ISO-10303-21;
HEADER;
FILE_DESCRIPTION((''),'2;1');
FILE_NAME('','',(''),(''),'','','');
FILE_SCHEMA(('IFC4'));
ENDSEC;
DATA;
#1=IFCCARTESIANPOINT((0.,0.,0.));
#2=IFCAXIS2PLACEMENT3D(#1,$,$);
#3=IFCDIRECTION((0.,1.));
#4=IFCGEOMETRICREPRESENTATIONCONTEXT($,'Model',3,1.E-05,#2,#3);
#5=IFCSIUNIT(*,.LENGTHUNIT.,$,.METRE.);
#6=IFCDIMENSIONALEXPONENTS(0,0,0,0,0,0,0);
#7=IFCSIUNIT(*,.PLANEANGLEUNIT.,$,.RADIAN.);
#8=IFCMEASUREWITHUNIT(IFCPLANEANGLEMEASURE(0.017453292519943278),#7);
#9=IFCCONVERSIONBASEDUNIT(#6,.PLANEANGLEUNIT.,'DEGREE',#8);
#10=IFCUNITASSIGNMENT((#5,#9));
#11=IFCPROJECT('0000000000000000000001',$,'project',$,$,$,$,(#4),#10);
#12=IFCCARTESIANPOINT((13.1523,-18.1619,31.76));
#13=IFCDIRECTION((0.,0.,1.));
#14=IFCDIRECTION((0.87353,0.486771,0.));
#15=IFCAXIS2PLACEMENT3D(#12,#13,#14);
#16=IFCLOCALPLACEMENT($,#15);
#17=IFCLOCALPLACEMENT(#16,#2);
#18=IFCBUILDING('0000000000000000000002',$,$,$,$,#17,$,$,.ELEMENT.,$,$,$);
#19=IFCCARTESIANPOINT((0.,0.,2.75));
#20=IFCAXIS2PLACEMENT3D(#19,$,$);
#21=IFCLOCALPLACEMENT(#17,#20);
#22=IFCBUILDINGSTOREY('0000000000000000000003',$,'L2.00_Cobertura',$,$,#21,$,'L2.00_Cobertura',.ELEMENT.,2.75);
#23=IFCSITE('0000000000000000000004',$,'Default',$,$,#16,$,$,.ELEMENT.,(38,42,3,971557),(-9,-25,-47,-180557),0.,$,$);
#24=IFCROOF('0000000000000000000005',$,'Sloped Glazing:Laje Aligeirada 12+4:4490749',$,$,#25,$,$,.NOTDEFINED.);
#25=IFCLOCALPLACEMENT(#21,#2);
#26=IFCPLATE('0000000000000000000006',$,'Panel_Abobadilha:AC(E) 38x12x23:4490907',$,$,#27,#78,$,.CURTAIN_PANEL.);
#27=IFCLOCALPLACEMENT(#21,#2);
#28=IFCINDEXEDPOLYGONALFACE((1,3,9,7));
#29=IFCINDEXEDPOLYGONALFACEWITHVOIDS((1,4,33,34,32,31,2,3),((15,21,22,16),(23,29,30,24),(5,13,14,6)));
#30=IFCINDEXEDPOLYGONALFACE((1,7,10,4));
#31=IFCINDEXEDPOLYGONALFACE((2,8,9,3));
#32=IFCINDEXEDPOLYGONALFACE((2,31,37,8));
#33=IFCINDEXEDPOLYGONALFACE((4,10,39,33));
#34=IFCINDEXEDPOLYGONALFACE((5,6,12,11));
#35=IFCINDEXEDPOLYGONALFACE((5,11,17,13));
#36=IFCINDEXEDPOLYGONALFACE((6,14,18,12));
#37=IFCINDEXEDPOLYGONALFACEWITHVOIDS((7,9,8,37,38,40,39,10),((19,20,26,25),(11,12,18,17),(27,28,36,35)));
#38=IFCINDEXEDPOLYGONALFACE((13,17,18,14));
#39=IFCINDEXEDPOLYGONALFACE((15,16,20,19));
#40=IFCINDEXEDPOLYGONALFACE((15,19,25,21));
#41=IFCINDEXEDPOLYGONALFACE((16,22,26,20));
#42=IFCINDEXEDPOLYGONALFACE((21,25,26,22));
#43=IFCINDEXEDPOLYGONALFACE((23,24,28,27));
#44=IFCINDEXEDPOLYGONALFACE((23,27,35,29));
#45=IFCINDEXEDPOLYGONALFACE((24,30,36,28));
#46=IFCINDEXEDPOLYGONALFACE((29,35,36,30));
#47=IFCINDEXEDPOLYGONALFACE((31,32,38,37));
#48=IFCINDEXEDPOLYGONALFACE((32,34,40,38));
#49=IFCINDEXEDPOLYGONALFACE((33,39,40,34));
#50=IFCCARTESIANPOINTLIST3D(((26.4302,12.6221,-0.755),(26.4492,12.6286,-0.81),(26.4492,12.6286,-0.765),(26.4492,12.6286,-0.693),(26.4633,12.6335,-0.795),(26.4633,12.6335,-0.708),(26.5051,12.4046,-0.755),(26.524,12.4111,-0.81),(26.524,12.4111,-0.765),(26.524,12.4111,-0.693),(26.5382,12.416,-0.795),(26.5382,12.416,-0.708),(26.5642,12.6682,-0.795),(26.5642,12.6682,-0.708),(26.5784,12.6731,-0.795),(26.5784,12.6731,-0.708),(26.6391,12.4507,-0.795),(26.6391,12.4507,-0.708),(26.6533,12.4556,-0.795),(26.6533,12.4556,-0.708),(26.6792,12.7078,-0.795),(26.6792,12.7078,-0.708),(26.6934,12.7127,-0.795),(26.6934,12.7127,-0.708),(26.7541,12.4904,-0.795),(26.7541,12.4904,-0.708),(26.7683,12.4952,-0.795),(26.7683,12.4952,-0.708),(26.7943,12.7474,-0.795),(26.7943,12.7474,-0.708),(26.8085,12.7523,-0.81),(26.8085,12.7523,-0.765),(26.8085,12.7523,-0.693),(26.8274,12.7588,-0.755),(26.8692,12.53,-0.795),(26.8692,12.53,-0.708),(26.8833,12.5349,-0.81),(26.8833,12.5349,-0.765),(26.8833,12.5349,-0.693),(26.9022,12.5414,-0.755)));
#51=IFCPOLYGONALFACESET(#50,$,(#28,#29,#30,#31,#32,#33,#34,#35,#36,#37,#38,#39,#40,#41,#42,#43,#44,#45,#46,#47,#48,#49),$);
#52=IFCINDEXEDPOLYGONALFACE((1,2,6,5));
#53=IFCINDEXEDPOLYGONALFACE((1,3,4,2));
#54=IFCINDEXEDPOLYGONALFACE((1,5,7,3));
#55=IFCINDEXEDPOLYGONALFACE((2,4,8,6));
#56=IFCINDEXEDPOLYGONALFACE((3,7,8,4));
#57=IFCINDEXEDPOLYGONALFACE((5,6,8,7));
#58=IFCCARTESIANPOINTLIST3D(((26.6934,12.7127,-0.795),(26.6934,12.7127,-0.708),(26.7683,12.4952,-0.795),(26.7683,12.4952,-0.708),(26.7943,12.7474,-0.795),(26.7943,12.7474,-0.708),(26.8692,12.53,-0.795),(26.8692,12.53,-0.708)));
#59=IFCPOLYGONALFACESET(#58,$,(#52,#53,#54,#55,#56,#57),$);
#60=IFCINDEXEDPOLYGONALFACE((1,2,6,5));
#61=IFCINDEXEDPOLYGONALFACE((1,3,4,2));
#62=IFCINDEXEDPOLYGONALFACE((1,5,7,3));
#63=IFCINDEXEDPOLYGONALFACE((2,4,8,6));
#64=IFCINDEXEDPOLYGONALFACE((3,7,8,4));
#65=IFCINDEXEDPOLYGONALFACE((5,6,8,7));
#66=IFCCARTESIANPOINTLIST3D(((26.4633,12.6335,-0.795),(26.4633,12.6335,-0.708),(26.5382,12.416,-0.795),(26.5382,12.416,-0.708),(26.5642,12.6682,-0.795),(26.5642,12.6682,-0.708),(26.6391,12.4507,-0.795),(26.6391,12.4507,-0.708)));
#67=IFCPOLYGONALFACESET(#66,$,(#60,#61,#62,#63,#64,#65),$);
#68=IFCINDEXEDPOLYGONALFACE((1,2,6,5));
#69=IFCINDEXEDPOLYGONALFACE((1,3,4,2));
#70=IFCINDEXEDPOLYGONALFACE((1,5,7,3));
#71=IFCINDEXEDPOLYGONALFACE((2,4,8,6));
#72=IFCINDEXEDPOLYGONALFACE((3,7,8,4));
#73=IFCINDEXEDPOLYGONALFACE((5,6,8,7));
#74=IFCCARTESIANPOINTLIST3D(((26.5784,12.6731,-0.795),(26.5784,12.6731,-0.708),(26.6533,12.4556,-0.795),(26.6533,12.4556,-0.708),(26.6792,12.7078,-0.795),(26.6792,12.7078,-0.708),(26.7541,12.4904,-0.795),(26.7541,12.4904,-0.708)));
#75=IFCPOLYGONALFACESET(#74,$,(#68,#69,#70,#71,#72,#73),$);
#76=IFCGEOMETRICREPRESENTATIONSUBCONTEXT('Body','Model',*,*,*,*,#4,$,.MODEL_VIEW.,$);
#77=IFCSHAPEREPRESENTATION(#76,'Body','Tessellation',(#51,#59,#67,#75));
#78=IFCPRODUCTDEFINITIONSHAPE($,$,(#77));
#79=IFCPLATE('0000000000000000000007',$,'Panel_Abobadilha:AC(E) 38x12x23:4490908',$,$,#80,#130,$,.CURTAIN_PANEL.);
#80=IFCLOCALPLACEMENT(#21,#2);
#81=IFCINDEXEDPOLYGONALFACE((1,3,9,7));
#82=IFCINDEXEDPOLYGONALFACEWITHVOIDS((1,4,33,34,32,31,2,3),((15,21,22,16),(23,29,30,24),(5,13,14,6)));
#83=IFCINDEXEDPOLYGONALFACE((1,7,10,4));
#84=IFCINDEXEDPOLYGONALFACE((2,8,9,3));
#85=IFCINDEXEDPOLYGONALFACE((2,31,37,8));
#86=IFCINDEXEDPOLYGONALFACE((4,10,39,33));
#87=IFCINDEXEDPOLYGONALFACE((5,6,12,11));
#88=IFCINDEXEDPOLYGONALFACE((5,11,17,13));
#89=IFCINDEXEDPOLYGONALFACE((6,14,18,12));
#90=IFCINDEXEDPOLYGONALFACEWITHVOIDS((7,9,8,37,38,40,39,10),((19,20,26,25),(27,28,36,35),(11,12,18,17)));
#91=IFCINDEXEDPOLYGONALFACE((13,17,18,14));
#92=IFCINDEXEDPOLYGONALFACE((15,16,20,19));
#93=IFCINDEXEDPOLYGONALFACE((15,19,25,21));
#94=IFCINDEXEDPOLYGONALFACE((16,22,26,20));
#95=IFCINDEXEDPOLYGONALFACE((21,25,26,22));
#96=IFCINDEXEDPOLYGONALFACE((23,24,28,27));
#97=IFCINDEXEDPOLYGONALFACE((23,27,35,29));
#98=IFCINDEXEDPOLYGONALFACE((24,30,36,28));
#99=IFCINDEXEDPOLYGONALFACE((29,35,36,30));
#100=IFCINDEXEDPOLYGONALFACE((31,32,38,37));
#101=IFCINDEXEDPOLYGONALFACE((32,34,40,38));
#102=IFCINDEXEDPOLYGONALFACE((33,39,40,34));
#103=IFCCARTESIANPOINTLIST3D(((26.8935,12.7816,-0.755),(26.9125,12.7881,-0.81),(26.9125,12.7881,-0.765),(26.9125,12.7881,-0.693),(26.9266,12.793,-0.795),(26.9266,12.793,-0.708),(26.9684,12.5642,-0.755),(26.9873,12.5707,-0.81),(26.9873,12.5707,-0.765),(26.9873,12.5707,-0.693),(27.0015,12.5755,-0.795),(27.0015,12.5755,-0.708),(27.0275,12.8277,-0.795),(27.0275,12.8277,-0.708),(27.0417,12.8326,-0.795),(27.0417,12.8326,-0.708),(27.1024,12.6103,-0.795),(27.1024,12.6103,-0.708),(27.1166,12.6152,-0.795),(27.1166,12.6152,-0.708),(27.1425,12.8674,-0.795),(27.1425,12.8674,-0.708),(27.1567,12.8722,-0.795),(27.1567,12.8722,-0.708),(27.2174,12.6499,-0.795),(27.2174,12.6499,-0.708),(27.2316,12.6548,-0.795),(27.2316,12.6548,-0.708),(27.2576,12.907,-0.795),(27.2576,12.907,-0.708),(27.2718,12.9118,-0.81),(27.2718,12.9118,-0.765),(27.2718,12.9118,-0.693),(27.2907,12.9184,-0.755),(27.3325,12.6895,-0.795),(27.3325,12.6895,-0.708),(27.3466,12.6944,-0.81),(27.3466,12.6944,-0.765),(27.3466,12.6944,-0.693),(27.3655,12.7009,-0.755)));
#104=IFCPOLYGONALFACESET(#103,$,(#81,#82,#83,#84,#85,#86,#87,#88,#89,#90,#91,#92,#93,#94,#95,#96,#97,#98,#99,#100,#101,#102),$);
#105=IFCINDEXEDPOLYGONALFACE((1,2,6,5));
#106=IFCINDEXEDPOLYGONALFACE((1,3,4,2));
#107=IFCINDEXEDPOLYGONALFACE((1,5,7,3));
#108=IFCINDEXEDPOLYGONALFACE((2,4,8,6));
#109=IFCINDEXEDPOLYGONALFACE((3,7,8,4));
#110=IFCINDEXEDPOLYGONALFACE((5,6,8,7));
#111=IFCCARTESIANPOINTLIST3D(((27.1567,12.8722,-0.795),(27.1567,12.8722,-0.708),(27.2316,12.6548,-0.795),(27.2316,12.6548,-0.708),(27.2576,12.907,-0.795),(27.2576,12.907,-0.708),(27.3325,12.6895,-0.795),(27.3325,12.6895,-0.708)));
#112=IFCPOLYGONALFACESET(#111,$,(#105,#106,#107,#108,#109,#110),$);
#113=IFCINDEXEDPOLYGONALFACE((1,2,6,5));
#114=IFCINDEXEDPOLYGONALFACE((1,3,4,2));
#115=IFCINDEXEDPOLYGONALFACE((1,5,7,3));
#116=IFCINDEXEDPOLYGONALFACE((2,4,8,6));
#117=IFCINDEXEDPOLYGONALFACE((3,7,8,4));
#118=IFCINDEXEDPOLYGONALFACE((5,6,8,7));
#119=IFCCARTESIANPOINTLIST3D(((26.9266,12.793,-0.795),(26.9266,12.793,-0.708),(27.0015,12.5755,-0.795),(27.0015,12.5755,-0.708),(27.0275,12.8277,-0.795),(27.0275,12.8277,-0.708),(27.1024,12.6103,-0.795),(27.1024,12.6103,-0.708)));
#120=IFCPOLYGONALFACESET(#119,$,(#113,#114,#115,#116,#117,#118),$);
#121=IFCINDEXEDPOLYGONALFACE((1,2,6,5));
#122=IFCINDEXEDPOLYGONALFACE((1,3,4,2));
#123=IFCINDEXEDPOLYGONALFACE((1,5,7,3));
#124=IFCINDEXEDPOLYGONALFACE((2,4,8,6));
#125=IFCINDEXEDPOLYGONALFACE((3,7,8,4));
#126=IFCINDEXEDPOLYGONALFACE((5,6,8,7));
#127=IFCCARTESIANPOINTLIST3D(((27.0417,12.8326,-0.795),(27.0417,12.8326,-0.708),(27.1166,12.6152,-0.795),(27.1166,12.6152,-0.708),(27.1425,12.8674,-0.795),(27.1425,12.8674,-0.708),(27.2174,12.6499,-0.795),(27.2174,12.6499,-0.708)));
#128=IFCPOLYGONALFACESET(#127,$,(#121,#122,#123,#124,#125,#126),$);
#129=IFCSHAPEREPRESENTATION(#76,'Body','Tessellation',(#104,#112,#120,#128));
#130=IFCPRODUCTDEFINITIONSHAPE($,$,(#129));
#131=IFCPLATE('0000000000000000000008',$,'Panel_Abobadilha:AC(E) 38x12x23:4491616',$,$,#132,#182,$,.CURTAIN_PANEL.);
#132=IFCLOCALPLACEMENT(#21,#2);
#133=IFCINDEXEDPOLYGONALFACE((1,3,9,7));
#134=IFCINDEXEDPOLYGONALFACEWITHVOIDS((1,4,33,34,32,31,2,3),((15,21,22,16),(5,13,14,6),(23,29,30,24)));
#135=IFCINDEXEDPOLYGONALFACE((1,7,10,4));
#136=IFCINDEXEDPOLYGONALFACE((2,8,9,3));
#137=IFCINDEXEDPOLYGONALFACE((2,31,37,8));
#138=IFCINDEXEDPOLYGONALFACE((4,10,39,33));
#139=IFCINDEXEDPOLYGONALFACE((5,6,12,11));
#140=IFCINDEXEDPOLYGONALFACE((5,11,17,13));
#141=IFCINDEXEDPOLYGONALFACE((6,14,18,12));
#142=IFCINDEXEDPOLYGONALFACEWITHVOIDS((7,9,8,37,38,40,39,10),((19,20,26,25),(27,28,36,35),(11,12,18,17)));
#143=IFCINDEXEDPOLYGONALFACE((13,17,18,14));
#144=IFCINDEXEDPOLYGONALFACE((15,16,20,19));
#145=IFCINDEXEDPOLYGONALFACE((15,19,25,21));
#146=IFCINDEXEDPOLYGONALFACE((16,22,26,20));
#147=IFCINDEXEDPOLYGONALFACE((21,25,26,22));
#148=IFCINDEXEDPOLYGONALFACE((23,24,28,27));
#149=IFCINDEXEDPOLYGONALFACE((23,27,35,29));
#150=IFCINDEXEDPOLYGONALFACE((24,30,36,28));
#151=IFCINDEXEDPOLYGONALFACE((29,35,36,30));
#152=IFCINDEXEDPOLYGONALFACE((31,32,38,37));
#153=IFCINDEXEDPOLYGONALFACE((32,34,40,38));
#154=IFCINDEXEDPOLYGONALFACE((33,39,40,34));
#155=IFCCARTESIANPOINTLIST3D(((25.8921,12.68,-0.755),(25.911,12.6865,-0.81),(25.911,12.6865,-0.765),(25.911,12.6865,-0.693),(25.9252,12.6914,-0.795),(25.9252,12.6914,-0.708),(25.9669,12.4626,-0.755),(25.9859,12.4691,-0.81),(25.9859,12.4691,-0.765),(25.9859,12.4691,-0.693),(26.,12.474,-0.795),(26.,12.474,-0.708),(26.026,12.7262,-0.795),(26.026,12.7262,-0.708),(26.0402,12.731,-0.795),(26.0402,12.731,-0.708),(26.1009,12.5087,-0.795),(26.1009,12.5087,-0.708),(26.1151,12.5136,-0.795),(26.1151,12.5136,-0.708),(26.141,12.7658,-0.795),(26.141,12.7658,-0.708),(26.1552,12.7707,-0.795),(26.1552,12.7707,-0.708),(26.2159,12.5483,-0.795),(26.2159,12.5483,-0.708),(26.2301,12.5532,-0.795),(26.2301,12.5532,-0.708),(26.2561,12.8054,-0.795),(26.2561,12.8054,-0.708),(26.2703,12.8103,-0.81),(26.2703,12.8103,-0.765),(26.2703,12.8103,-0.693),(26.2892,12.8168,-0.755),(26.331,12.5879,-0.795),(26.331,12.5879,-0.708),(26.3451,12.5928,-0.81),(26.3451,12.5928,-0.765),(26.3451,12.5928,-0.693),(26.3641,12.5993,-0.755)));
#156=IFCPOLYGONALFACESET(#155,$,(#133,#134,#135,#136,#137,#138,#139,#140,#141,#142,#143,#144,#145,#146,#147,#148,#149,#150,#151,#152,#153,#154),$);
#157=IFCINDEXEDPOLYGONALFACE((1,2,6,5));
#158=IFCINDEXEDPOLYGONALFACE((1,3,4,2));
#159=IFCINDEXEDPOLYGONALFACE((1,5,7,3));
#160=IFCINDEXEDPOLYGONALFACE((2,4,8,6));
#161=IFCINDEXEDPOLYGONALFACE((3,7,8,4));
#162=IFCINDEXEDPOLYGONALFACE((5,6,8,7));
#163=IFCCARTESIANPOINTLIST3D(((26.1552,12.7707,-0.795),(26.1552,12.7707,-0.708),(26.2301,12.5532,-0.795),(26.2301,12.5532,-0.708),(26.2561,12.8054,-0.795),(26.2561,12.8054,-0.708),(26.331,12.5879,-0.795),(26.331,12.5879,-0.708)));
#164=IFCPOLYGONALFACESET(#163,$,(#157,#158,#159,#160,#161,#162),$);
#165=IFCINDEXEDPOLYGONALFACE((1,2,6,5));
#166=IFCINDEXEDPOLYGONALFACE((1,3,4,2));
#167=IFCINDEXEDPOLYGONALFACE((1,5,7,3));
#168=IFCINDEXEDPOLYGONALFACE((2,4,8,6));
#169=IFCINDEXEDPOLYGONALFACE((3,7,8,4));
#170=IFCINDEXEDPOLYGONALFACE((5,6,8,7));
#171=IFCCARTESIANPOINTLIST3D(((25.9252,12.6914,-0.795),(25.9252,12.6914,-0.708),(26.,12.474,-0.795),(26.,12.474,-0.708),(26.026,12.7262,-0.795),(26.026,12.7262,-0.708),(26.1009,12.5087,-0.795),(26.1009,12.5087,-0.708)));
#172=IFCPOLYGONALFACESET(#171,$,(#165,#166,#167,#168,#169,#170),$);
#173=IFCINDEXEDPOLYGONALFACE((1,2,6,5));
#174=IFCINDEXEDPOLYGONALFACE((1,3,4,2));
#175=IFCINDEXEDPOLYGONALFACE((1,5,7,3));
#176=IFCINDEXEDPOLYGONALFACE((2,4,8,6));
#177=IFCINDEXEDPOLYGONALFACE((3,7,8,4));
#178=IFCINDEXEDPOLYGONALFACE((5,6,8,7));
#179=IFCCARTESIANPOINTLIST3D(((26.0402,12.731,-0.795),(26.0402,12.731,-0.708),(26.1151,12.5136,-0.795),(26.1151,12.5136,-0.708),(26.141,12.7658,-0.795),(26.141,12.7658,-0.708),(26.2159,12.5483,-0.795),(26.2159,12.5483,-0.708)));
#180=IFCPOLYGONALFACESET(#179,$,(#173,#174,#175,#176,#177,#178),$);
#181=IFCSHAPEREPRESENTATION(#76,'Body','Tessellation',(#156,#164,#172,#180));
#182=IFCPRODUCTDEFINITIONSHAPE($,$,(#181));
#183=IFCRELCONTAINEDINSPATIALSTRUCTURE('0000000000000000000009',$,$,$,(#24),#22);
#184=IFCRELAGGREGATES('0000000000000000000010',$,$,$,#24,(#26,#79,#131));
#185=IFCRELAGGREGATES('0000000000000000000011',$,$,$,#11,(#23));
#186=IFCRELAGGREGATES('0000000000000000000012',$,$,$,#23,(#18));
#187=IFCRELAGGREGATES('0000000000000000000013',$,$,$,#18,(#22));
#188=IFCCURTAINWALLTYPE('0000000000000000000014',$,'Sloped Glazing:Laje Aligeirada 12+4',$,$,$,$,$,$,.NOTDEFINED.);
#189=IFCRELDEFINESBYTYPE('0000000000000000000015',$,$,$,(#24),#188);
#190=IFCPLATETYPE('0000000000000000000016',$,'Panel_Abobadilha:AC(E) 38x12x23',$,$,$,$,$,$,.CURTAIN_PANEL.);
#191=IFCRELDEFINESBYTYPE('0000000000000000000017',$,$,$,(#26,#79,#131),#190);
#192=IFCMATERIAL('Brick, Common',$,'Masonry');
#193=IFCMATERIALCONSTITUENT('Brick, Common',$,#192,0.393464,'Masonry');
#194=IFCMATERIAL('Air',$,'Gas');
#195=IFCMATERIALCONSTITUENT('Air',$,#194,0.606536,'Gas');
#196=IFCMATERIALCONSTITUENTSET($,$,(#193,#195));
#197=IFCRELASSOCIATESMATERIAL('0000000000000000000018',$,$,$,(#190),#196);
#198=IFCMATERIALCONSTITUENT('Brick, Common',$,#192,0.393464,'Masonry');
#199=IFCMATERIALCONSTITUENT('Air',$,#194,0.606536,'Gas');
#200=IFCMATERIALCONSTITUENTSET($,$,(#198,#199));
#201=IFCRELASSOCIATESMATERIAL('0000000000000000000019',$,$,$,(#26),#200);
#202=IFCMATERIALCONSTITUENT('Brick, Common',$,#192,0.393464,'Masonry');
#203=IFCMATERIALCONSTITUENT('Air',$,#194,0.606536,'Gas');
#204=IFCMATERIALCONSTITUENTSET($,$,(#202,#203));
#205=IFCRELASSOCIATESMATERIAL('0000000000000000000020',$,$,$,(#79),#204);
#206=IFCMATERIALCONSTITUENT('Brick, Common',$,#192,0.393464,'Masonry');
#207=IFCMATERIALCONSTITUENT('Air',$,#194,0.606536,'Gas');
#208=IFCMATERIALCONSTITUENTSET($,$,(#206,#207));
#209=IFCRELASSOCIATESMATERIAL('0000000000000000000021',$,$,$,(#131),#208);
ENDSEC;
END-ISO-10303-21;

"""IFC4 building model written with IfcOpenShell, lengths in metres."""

from ifc_helpers import new_model, entity, si_unit, converted_unit, direction, frame, origin, place, context, subcontext, project, spatial, indexed_curve, outline, extrude, source, transform, mapped, material, constituent, constituent_set, type_object, type_shapes, element, aggregate, save


model = new_model("IFC4")

# Units and contexts
model_context = context("Model", 3, precision=1e-05, world=origin(), true_north=direction((0.0, 1.0)))
body_context = subcontext(model_context, "Body", "Model", "MODEL_VIEW")
ifc_project = project(units=[si_unit("LENGTHUNIT", "METRE"), converted_unit("PLANEANGLEUNIT", "DEGREE", entity("IfcPlaneAngleMeasure", 0.017453292519943278), si_unit("PLANEANGLEUNIT", "RADIAN"), dimensions=[0, 0, 0, 0, 0, 0, 0])], contexts=[model_context])

# Site, building, storey
site_placement = place(None, frame((13.1523, -18.1619, 31.76), z_axis=(0.0, 0.0, 1.0), x_axis=(0.87353, 0.486771, 0.0)))
site = spatial("IfcSite", under=ifc_project, at=site_placement, Name="Default", CompositionType="ELEMENT", RefLatitude=(38, 42, 3, 971557), RefLongitude=(-9, -25, -47, -180557), RefElevation=0.0)
building_placement = place(site_placement, origin())
building = spatial("IfcBuilding", under=site, at=building_placement, CompositionType="ELEMENT")
storey_placement = place(building_placement, frame((0.0, 0.0, 2.75)))
storey = spatial("IfcBuildingStorey", under=building, at=storey_placement, Name="L2.00_Cobertura", LongName="L2.00_Cobertura", CompositionType="ELEMENT", Elevation=2.75)

# Roof, plates
curtain_wall_type = type_object("IfcCurtainWallType", Name="Sloped Glazing:Laje Aligeirada 12+4", PredefinedType="NOTDEFINED")
roof_placement = place(storey_placement, frame((0.0, 0.0, -2.75)))
roof = element("IfcRoof", 1, at=roof_placement, inside=storey, type_object=curtain_wall_type, Name="Sloped Glazing:Laje Aligeirada 12+4:4490749", PredefinedType="NOTDEFINED")
ifc_material_1 = material(Name="Brick, Common", Category="Masonry")
ifc_material_2 = material(Name="Air", Category="Gas")
ifc_constituent_1 = constituent(ifc_material_1, Name="Brick, Common", Category="Masonry", fraction=0.393464)
ifc_constituent_2 = constituent(ifc_material_2, Name="Air", Category="Gas", fraction=0.606536)
ifc_constituent_set_1 = constituent_set(constituents=[ifc_constituent_1, ifc_constituent_2])
plate_type = type_object("IfcPlateType", Name="Panel_Abobadilha:AC(E) 38x12x23", PredefinedType="CURTAIN_PANEL", material=ifc_constituent_set_1)
shared_shape_1 = source(origin(), body_context, "Body", "SweptSolid", [
    extrude(outline(indexed_curve([(-0.19, -0.0543), (0.19, -0.0543), (0.19, -0.0093), (0.21, 0.0007), (0.19, 0.0628), (-0.19, 0.0628), (-0.21, 0.0007), (-0.19, -0.0093), (-0.19, -0.0543)], self_intersect=False), holes=[indexed_curve([(-0.0683, 0.0477), (-0.0683, -0.0393), (-0.175, -0.0393), (-0.175, 0.0477), (-0.0683, 0.0477)], self_intersect=False), indexed_curve([(0.0533, 0.0477), (0.0533, -0.0393), (-0.0533, -0.0393), (-0.0533, 0.0477), (0.0533, 0.0477)], self_intersect=False), indexed_curve([(0.175, 0.0477), (0.175, -0.0393), (0.0683, -0.0393), (0.0683, 0.0477), (0.175, 0.0477)], self_intersect=False)]), frame((0.0, 0.0543, 0.0)), (0.0, 0.0, 1.0), 0.23),
    extrude(outline(indexed_curve([(-0.0533, -0.0435), (0.0533, -0.0435), (0.0533, 0.0435), (-0.0533, 0.0435), (-0.0533, -0.0435)], self_intersect=False)), frame((0.1217, 0.0585, 0.0), z_axis=(0.0, 0.0, 1.0), x_axis=(-1.0, 0.0, 0.0)), (0.0, 0.0, 1.0), 0.23),
    extrude(outline(indexed_curve([(-0.0533, -0.0435), (0.0533, -0.0435), (0.0533, 0.0435), (-0.0533, 0.0435), (-0.0533, -0.0435)], self_intersect=False)), frame((-0.1217, 0.0585, 0.0), z_axis=(0.0, 0.0, 1.0), x_axis=(-1.0, 0.0, 0.0)), (0.0, 0.0, 1.0), 0.23),
    extrude(outline(indexed_curve([(-0.0533, -0.0435), (0.0533, -0.0435), (0.0533, 0.0435), (-0.0533, 0.0435), (-0.0533, -0.0435)], self_intersect=False)), frame((0.0, 0.0585, 0.0), z_axis=(0.0, 0.0, 1.0), x_axis=(-1.0, 0.0, 0.0)), (0.0, 0.0, 1.0), 0.23),
])
type_shapes(plate_type, [shared_shape_1])
ifc_constituent_3 = constituent(ifc_material_1, Name="Brick, Common", Category="Masonry", fraction=0.393464)
ifc_constituent_4 = constituent(ifc_material_2, Name="Air", Category="Gas", fraction=0.606536)
ifc_constituent_set_2 = constituent_set(constituents=[ifc_constituent_3, ifc_constituent_4])
plate_1_placement = place(roof_placement, frame((26.6288, 12.6905, 1.94), z_axis=(0.325568, -0.945519, 0.0), x_axis=(0.945519, 0.325568, 0.0)))
plate_1 = element("IfcPlate", 2, at=plate_1_placement, type_object=plate_type, material=ifc_constituent_set_2, Name="Panel_Abobadilha:AC(E) 38x12x23:4490907", PredefinedType="CURTAIN_PANEL", context=body_context, shape_type="MappedRepresentation", body=[
    mapped(shared_shape_1, transform((0.0, 0.0, 0.0), scale=1.0)),
])
ifc_constituent_5 = constituent(ifc_material_1, Name="Brick, Common", Category="Masonry", fraction=0.393464)
ifc_constituent_6 = constituent(ifc_material_2, Name="Air", Category="Gas", fraction=0.606536)
ifc_constituent_set_3 = constituent_set(constituents=[ifc_constituent_5, ifc_constituent_6])
plate_2_placement = place(roof_placement, frame((27.0921, 12.85, 1.94), z_axis=(0.325568, -0.945519, 0.0), x_axis=(0.945519, 0.325568, 0.0)))
plate_2 = element("IfcPlate", 3, at=plate_2_placement, type_object=plate_type, material=ifc_constituent_set_3, Name="Panel_Abobadilha:AC(E) 38x12x23:4490908", PredefinedType="CURTAIN_PANEL", context=body_context, shape_type="MappedRepresentation", body=[
    mapped(shared_shape_1, transform((0.0, 0.0, 0.0), scale=1.0)),
])
ifc_constituent_7 = constituent(ifc_material_1, Name="Brick, Common", Category="Masonry", fraction=0.393464)
ifc_constituent_8 = constituent(ifc_material_2, Name="Air", Category="Gas", fraction=0.606536)
ifc_constituent_set_4 = constituent_set(constituents=[ifc_constituent_7, ifc_constituent_8])
plate_3_placement = place(roof_placement, frame((26.0906, 12.7484, 1.94), z_axis=(0.325568, -0.945519, 0.0), x_axis=(0.945519, 0.325568, 0.0)))
plate_3 = element("IfcPlate", 4, at=plate_3_placement, type_object=plate_type, material=ifc_constituent_set_4, Name="Panel_Abobadilha:AC(E) 38x12x23:4491616", PredefinedType="CURTAIN_PANEL", context=body_context, shape_type="MappedRepresentation", body=[
    mapped(shared_shape_1, transform((0.0, 0.0, 0.0), scale=1.0)),
])
aggregate(roof, [plate_1, plate_2, plate_3])

save(model, "model.ifc")
